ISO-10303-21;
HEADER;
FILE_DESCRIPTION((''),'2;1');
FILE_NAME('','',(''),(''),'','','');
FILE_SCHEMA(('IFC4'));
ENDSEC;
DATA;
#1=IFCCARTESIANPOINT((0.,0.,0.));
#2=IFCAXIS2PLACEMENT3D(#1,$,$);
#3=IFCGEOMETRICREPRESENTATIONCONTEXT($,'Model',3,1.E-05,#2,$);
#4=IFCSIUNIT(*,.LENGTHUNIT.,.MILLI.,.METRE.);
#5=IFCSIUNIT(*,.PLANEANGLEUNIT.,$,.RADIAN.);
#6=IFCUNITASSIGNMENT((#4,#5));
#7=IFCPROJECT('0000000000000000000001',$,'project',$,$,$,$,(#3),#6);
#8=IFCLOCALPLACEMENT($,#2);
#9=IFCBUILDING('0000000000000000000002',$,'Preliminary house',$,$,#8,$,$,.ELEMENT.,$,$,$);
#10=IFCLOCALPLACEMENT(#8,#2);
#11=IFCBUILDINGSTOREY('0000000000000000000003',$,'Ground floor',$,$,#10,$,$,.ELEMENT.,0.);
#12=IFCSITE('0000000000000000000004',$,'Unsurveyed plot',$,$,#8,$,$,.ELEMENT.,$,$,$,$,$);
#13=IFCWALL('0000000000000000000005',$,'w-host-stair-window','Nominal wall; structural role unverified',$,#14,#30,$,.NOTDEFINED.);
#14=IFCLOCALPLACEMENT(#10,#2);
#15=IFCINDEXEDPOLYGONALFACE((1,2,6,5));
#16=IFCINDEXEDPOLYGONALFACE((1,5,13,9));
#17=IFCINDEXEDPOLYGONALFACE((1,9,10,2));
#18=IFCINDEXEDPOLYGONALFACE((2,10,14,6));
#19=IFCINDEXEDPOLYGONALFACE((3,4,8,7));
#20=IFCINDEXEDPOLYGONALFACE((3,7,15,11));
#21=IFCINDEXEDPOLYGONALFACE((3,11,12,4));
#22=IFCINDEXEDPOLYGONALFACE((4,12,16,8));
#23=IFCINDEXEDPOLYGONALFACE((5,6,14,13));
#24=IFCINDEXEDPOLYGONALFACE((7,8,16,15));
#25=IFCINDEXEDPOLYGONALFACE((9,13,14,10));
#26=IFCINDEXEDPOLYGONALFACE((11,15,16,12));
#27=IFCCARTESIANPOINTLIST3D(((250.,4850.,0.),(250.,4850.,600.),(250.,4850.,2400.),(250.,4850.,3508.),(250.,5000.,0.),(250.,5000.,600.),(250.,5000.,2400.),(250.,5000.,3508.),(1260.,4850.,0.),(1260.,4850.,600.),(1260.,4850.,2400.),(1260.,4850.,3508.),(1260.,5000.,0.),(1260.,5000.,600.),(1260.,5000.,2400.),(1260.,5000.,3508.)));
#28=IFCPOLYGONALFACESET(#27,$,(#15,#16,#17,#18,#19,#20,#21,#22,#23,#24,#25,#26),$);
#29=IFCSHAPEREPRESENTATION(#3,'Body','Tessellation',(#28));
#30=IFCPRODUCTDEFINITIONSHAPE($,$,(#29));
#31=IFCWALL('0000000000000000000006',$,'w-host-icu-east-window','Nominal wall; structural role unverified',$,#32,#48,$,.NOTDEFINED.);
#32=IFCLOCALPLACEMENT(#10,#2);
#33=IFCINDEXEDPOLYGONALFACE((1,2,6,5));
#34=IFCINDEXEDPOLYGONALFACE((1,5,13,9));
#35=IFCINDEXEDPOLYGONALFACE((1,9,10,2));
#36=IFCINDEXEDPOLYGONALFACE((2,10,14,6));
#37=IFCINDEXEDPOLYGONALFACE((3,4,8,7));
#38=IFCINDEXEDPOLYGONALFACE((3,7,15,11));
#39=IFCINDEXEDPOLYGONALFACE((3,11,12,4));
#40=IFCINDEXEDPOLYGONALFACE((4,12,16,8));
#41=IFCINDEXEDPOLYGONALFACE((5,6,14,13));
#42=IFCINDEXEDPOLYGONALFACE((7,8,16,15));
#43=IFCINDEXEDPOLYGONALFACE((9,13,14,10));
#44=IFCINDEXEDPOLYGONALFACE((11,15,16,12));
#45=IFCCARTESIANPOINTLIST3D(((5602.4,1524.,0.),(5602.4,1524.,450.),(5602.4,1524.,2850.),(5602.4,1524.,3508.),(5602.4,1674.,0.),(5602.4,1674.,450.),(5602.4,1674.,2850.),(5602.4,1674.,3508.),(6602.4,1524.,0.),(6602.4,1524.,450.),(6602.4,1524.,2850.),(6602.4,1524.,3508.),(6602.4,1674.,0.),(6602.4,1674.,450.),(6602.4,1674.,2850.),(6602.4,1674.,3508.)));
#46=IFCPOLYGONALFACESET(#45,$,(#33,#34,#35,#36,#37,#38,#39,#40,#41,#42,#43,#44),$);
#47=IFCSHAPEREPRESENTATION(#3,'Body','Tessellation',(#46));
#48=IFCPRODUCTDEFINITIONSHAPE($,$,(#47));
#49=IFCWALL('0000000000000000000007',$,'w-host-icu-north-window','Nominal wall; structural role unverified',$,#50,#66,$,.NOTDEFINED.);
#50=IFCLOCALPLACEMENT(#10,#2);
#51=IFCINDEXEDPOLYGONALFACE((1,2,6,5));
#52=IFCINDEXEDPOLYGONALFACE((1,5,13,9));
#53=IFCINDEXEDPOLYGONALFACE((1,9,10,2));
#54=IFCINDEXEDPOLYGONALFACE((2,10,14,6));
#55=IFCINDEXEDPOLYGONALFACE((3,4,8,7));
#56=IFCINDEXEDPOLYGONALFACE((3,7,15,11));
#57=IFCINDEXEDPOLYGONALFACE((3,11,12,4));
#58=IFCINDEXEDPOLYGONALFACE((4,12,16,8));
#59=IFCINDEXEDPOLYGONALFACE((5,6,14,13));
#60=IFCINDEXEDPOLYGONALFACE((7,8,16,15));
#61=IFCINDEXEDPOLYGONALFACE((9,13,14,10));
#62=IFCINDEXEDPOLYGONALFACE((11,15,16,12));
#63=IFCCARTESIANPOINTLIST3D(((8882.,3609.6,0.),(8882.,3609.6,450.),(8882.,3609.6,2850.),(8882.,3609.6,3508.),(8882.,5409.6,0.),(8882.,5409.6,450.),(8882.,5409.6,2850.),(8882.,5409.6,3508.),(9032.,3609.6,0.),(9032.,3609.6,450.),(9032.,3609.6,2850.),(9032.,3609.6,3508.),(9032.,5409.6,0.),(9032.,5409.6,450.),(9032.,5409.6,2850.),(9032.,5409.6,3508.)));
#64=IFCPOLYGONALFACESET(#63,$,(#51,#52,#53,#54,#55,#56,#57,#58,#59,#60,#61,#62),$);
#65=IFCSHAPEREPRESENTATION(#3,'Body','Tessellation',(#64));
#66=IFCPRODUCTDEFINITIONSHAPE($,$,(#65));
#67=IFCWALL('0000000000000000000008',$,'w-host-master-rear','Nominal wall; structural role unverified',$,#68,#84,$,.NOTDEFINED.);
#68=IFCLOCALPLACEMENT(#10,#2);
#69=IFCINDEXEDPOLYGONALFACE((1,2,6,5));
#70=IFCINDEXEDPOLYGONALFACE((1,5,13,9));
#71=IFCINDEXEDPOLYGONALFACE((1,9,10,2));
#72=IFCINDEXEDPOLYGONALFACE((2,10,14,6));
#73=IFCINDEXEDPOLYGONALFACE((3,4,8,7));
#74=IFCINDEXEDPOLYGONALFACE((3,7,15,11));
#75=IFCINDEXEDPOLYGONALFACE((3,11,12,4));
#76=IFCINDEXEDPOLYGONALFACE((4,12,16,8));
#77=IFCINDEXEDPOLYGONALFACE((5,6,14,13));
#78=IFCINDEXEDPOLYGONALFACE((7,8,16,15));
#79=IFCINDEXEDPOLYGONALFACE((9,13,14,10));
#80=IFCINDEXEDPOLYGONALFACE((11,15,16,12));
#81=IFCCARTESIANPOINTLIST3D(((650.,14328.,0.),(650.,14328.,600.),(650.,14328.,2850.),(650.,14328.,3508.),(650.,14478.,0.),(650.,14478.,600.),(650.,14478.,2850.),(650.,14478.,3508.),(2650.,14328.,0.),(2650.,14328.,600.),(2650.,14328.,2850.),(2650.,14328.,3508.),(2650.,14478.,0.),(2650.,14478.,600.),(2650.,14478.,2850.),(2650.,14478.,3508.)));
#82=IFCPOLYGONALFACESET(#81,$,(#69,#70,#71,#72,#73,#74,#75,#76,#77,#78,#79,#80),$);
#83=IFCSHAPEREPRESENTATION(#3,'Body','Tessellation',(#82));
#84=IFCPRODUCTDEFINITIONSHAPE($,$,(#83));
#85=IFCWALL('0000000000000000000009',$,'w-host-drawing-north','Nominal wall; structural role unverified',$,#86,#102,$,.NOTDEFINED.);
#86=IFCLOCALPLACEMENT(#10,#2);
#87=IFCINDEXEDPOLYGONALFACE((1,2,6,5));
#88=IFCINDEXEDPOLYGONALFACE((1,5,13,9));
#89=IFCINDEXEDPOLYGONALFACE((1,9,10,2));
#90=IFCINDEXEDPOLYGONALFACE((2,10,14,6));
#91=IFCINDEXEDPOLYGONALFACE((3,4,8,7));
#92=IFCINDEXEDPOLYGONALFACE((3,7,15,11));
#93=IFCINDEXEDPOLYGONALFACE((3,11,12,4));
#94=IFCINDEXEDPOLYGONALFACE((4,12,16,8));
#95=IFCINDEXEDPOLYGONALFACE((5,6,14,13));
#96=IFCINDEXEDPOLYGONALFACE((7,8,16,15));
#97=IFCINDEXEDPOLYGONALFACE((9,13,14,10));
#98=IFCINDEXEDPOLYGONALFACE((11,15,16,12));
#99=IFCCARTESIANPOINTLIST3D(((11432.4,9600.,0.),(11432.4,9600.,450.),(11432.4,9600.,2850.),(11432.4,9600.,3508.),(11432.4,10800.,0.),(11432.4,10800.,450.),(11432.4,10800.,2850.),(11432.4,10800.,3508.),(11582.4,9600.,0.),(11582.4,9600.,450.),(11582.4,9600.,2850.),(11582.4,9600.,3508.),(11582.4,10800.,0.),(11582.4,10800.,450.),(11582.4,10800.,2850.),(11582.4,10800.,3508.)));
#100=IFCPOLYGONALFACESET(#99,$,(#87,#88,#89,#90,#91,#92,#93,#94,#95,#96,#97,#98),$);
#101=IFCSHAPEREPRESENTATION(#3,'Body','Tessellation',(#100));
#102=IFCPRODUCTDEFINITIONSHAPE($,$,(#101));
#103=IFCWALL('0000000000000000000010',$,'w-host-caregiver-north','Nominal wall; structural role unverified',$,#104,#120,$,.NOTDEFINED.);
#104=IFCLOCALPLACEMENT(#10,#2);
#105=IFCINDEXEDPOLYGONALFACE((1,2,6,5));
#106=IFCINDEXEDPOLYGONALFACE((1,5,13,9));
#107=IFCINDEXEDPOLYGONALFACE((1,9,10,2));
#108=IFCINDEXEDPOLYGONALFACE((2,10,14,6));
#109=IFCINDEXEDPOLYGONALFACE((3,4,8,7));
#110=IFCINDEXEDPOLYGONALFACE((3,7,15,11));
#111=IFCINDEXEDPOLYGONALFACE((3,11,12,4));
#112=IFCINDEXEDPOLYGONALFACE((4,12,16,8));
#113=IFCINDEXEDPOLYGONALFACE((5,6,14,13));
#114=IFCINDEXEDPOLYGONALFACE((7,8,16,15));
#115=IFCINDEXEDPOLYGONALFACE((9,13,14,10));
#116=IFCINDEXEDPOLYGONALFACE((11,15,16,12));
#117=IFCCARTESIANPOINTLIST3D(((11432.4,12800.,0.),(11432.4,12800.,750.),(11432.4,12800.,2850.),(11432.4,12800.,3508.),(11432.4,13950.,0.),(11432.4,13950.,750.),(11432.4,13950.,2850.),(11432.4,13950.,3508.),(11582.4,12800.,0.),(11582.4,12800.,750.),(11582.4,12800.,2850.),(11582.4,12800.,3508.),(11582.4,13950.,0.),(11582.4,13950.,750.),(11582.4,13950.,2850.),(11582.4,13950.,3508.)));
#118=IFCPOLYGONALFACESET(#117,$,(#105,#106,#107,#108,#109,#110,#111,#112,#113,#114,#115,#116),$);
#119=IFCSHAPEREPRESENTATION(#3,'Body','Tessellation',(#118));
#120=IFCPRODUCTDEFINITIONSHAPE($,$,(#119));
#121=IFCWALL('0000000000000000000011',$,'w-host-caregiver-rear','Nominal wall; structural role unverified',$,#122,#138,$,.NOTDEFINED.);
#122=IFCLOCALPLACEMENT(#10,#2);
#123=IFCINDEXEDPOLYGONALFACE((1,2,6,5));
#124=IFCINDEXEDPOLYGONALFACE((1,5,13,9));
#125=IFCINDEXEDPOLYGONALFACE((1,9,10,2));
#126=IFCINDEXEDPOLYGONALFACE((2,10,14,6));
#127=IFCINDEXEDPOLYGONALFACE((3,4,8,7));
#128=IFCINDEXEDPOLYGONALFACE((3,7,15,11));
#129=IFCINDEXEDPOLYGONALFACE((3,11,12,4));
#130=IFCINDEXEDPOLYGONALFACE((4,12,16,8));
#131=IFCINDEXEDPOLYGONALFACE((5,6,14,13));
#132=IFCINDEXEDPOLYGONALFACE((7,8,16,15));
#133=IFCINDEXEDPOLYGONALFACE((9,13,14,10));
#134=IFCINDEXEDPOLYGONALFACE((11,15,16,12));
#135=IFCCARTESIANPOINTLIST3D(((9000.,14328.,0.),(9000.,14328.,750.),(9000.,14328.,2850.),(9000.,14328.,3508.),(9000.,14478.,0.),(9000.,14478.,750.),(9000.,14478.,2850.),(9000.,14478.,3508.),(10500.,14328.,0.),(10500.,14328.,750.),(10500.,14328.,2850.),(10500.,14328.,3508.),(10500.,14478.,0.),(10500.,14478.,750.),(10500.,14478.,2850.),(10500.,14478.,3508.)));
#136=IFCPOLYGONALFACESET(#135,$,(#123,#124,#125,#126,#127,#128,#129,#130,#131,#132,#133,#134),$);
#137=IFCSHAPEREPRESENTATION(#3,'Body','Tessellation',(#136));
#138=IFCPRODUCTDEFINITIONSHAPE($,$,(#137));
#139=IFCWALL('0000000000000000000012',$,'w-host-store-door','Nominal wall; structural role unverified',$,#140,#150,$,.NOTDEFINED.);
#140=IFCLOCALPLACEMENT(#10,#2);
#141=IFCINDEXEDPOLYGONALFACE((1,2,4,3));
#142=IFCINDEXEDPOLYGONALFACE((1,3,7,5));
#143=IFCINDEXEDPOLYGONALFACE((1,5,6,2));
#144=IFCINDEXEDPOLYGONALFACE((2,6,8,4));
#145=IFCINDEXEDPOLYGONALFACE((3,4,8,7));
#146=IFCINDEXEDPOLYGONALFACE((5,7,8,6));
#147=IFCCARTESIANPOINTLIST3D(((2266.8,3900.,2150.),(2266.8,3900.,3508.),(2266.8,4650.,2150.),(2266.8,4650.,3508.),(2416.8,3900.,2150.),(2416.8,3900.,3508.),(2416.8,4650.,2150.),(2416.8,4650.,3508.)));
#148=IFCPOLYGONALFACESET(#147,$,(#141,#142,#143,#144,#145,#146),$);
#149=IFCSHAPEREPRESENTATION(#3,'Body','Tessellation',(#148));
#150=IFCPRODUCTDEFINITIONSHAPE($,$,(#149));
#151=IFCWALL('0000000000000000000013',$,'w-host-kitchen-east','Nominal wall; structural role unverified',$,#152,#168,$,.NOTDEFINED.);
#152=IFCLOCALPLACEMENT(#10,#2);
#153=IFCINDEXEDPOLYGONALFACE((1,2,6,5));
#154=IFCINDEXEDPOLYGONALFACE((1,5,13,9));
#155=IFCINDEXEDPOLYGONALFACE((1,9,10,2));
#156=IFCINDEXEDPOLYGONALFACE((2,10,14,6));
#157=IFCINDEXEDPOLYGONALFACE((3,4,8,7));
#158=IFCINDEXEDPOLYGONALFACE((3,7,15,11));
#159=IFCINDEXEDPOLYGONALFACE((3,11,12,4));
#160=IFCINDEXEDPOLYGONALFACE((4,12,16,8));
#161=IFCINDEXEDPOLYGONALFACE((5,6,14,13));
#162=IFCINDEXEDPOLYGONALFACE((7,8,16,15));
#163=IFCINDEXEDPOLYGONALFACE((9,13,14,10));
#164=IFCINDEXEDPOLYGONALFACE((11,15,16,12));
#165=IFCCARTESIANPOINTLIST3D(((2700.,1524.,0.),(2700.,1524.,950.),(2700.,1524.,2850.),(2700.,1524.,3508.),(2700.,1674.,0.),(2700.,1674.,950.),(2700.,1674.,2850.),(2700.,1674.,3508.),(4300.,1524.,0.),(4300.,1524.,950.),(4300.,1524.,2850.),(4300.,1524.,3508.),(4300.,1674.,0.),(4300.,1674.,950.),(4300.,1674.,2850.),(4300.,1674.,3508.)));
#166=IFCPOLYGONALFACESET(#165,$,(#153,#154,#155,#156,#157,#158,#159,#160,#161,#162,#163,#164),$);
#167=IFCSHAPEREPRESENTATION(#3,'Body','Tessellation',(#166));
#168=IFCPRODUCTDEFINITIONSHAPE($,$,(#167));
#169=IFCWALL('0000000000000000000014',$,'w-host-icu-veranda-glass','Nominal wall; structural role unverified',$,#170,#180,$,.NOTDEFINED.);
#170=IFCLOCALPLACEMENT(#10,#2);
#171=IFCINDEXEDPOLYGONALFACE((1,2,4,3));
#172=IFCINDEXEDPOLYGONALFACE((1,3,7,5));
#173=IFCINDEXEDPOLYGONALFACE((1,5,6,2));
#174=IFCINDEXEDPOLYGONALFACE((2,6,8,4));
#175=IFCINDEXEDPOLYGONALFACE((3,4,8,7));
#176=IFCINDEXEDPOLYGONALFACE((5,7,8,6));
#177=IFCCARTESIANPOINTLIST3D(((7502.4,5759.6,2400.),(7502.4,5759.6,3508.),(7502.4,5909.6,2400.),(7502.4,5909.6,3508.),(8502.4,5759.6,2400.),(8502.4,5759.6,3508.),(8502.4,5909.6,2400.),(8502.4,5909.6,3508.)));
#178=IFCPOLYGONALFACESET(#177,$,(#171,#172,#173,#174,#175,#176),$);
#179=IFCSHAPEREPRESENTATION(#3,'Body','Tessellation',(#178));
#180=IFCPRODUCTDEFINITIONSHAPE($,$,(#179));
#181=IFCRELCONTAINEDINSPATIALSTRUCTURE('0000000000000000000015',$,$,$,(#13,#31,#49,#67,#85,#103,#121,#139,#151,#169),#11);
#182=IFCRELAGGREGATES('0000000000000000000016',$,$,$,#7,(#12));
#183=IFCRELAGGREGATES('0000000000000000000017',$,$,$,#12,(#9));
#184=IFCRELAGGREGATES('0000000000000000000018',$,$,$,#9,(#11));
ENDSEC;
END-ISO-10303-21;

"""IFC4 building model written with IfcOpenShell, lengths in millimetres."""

from ifc_helpers import new_model, si_unit, frame, origin, place, context, project, spatial, polyline, outline, extrude, element, save


model = new_model("IFC4")

# Units and contexts
model_context = context("Model", 3, precision=1e-05, world=origin())
ifc_project = project(units=[si_unit("LENGTHUNIT", "METRE", prefix="MILLI"), si_unit("PLANEANGLEUNIT", "RADIAN")], contexts=[model_context])

# Site, building, storey
placement_1 = place(None, origin())
site = spatial("IfcSite", under=ifc_project, at=placement_1, Name="Unsurveyed plot", CompositionType="ELEMENT")
building = spatial("IfcBuilding", under=site, at=placement_1, Name="Preliminary house", CompositionType="ELEMENT")
placement_2 = place(placement_1, origin())
storey = spatial("IfcBuildingStorey", under=building, at=placement_2, Name="Ground floor", CompositionType="ELEMENT", Elevation=0.0)

# Walls, openings
wall_1 = element("IfcWall", 1, at=placement_2, inside=storey, Name="w-host-stair-window", Description="Nominal wall; structural role unverified", PredefinedType="NOTDEFINED", context=model_context, shape_type="SweptSolid", body=[
    extrude(outline(polyline([(250.0, 4850.0), (1260.0, 4850.0), (1260.0, 5000.0), (250.0, 5000.0), (250.0, 4850.0)])), origin(), (0.0, 0.0, 1.0), 3508.0),
])
element("IfcOpeningElement", 2, at=placement_2, cuts=wall_1, PredefinedType="OPENING", context=model_context, shape_type="SweptSolid", body=[
    extrude(outline(polyline([(250.0, 4475.0), (1260.0, 4475.0), (1260.0, 5375.0), (250.0, 5375.0), (250.0, 4475.0)])), frame((0.0, 0.0, 600.0)), (0.0, 0.0, 1.0), 1800.0),
])
wall_2 = element("IfcWall", 3, at=placement_2, inside=storey, Name="w-host-icu-east-window", Description="Nominal wall; structural role unverified", PredefinedType="NOTDEFINED", context=model_context, shape_type="SweptSolid", body=[
    extrude(outline(polyline([(5602.4, 1524.0), (6602.4, 1524.0), (6602.4, 1674.0), (5602.4, 1674.0), (5602.4, 1524.0)])), origin(), (0.0, 0.0, 1.0), 3508.0),
])
element("IfcOpeningElement", 4, at=placement_2, cuts=wall_2, PredefinedType="OPENING", context=model_context, shape_type="SweptSolid", body=[
    extrude(outline(polyline([(5602.4, 1149.0), (6602.4, 1149.0), (6602.4, 2049.0), (5602.4, 2049.0), (5602.4, 1149.0)])), frame((0.0, 0.0, 450.0)), (0.0, 0.0, 1.0), 2400.0),
])
wall_3 = element("IfcWall", 5, at=placement_2, inside=storey, Name="w-host-icu-north-window", Description="Nominal wall; structural role unverified", PredefinedType="NOTDEFINED", context=model_context, shape_type="SweptSolid", body=[
    extrude(outline(polyline([(9032.0, 3609.6), (9032.0, 5409.6), (8882.0, 5409.6), (8882.0, 3609.6), (9032.0, 3609.6)])), origin(), (0.0, 0.0, 1.0), 3508.0),
])
element("IfcOpeningElement", 6, at=placement_2, cuts=wall_3, PredefinedType="OPENING", context=model_context, shape_type="SweptSolid", body=[
    extrude(outline(polyline([(9407.0, 3609.6), (9407.0, 5409.6), (8507.0, 5409.6), (8507.0, 3609.6), (9407.0, 3609.6)])), frame((0.0, 0.0, 450.0)), (0.0, 0.0, 1.0), 2400.0),
])
wall_4 = element("IfcWall", 7, at=placement_2, inside=storey, Name="w-host-master-rear", Description="Nominal wall; structural role unverified", PredefinedType="NOTDEFINED", context=model_context, shape_type="SweptSolid", body=[
    extrude(outline(polyline([(650.0, 14328.0), (2650.0, 14328.0), (2650.0, 14478.0), (650.0, 14478.0), (650.0, 14328.0)])), origin(), (0.0, 0.0, 1.0), 3508.0),
])
element("IfcOpeningElement", 8, at=placement_2, cuts=wall_4, PredefinedType="OPENING", context=model_context, shape_type="SweptSolid", body=[
    extrude(outline(polyline([(650.0, 13953.0), (2650.0, 13953.0), (2650.0, 14853.0), (650.0, 14853.0), (650.0, 13953.0)])), frame((0.0, 0.0, 600.0)), (0.0, 0.0, 1.0), 2250.0),
])
wall_5 = element("IfcWall", 9, at=placement_2, inside=storey, Name="w-host-drawing-north", Description="Nominal wall; structural role unverified", PredefinedType="NOTDEFINED", context=model_context, shape_type="SweptSolid", body=[
    extrude(outline(polyline([(11582.4, 9600.0), (11582.4, 10800.0), (11432.4, 10800.0), (11432.4, 9600.0), (11582.4, 9600.0)])), origin(), (0.0, 0.0, 1.0), 3508.0),
])
element("IfcOpeningElement", 10, at=placement_2, cuts=wall_5, PredefinedType="OPENING", context=model_context, shape_type="SweptSolid", body=[
    extrude(outline(polyline([(11957.4, 9600.0), (11957.4, 10800.0), (11057.4, 10800.0), (11057.4, 9600.0), (11957.4, 9600.0)])), frame((0.0, 0.0, 450.0)), (0.0, 0.0, 1.0), 2400.0),
])
wall_6 = element("IfcWall", 11, at=placement_2, inside=storey, Name="w-host-caregiver-north", Description="Nominal wall; structural role unverified", PredefinedType="NOTDEFINED", context=model_context, shape_type="SweptSolid", body=[
    extrude(outline(polyline([(11582.4, 12800.0), (11582.4, 13950.0), (11432.4, 13950.0), (11432.4, 12800.0), (11582.4, 12800.0)])), origin(), (0.0, 0.0, 1.0), 3508.0),
])
element("IfcOpeningElement", 12, at=placement_2, cuts=wall_6, PredefinedType="OPENING", context=model_context, shape_type="SweptSolid", body=[
    extrude(outline(polyline([(11957.4, 12800.0), (11957.4, 13950.0), (11057.4, 13950.0), (11057.4, 12800.0), (11957.4, 12800.0)])), frame((0.0, 0.0, 750.0)), (0.0, 0.0, 1.0), 2100.0),
])
wall_7 = element("IfcWall", 13, at=placement_2, inside=storey, Name="w-host-caregiver-rear", Description="Nominal wall; structural role unverified", PredefinedType="NOTDEFINED", context=model_context, shape_type="SweptSolid", body=[
    extrude(outline(polyline([(9000.0, 14328.0), (10500.0, 14328.0), (10500.0, 14478.0), (9000.0, 14478.0), (9000.0, 14328.0)])), origin(), (0.0, 0.0, 1.0), 3508.0),
])
element("IfcOpeningElement", 14, at=placement_2, cuts=wall_7, PredefinedType="OPENING", context=model_context, shape_type="SweptSolid", body=[
    extrude(outline(polyline([(9000.0, 13953.0), (10500.0, 13953.0), (10500.0, 14853.0), (9000.0, 14853.0), (9000.0, 13953.0)])), frame((0.0, 0.0, 750.0)), (0.0, 0.0, 1.0), 2100.0),
])
wall_8 = element("IfcWall", 15, at=placement_2, inside=storey, Name="w-host-store-door", Description="Nominal wall; structural role unverified", PredefinedType="NOTDEFINED", context=model_context, shape_type="SweptSolid", body=[
    extrude(outline(polyline([(2416.8, 3900.0), (2416.8, 4650.0), (2266.8, 4650.0), (2266.8, 3900.0), (2416.8, 3900.0)])), origin(), (0.0, 0.0, 1.0), 3508.0),
])
element("IfcOpeningElement", 16, at=placement_2, cuts=wall_8, PredefinedType="OPENING", context=model_context, shape_type="SweptSolid", body=[
    extrude(outline(polyline([(2791.8, 3900.0), (2791.8, 4650.0), (1891.8, 4650.0), (1891.8, 3900.0), (2791.8, 3900.0)])), origin(), (0.0, 0.0, 1.0), 2150.0),
])
wall_9 = element("IfcWall", 17, at=placement_2, inside=storey, Name="w-host-kitchen-east", Description="Nominal wall; structural role unverified", PredefinedType="NOTDEFINED", context=model_context, shape_type="SweptSolid", body=[
    extrude(outline(polyline([(2700.0, 1524.0), (4300.0, 1524.0), (4300.0, 1674.0), (2700.0, 1674.0), (2700.0, 1524.0)])), origin(), (0.0, 0.0, 1.0), 3508.0),
])
element("IfcOpeningElement", 18, at=placement_2, cuts=wall_9, PredefinedType="OPENING", context=model_context, shape_type="SweptSolid", body=[
    extrude(outline(polyline([(2700.0, 1149.0), (4300.0, 1149.0), (4300.0, 2049.0), (2700.0, 2049.0), (2700.0, 1149.0)])), frame((0.0, 0.0, 950.0)), (0.0, 0.0, 1.0), 1900.0),
])
wall_10 = element("IfcWall", 19, at=placement_2, inside=storey, Name="w-host-icu-veranda-glass", Description="Nominal wall; structural role unverified", PredefinedType="NOTDEFINED", context=model_context, shape_type="SweptSolid", body=[
    extrude(outline(polyline([(7502.4, 5759.6), (8502.4, 5759.6), (8502.4, 5909.6), (7502.4, 5909.6), (7502.4, 5759.6)])), origin(), (0.0, 0.0, 1.0), 3508.0),
])
element("IfcOpeningElement", 20, at=placement_2, cuts=wall_10, PredefinedType="OPENING", context=model_context, shape_type="SweptSolid", body=[
    extrude(outline(polyline([(7502.4, 5384.6), (8502.4, 5384.6), (8502.4, 6284.6), (7502.4, 6284.6), (7502.4, 5384.6)])), origin(), (0.0, 0.0, 1.0), 2400.0),
])

save(model, "model.ifc")
